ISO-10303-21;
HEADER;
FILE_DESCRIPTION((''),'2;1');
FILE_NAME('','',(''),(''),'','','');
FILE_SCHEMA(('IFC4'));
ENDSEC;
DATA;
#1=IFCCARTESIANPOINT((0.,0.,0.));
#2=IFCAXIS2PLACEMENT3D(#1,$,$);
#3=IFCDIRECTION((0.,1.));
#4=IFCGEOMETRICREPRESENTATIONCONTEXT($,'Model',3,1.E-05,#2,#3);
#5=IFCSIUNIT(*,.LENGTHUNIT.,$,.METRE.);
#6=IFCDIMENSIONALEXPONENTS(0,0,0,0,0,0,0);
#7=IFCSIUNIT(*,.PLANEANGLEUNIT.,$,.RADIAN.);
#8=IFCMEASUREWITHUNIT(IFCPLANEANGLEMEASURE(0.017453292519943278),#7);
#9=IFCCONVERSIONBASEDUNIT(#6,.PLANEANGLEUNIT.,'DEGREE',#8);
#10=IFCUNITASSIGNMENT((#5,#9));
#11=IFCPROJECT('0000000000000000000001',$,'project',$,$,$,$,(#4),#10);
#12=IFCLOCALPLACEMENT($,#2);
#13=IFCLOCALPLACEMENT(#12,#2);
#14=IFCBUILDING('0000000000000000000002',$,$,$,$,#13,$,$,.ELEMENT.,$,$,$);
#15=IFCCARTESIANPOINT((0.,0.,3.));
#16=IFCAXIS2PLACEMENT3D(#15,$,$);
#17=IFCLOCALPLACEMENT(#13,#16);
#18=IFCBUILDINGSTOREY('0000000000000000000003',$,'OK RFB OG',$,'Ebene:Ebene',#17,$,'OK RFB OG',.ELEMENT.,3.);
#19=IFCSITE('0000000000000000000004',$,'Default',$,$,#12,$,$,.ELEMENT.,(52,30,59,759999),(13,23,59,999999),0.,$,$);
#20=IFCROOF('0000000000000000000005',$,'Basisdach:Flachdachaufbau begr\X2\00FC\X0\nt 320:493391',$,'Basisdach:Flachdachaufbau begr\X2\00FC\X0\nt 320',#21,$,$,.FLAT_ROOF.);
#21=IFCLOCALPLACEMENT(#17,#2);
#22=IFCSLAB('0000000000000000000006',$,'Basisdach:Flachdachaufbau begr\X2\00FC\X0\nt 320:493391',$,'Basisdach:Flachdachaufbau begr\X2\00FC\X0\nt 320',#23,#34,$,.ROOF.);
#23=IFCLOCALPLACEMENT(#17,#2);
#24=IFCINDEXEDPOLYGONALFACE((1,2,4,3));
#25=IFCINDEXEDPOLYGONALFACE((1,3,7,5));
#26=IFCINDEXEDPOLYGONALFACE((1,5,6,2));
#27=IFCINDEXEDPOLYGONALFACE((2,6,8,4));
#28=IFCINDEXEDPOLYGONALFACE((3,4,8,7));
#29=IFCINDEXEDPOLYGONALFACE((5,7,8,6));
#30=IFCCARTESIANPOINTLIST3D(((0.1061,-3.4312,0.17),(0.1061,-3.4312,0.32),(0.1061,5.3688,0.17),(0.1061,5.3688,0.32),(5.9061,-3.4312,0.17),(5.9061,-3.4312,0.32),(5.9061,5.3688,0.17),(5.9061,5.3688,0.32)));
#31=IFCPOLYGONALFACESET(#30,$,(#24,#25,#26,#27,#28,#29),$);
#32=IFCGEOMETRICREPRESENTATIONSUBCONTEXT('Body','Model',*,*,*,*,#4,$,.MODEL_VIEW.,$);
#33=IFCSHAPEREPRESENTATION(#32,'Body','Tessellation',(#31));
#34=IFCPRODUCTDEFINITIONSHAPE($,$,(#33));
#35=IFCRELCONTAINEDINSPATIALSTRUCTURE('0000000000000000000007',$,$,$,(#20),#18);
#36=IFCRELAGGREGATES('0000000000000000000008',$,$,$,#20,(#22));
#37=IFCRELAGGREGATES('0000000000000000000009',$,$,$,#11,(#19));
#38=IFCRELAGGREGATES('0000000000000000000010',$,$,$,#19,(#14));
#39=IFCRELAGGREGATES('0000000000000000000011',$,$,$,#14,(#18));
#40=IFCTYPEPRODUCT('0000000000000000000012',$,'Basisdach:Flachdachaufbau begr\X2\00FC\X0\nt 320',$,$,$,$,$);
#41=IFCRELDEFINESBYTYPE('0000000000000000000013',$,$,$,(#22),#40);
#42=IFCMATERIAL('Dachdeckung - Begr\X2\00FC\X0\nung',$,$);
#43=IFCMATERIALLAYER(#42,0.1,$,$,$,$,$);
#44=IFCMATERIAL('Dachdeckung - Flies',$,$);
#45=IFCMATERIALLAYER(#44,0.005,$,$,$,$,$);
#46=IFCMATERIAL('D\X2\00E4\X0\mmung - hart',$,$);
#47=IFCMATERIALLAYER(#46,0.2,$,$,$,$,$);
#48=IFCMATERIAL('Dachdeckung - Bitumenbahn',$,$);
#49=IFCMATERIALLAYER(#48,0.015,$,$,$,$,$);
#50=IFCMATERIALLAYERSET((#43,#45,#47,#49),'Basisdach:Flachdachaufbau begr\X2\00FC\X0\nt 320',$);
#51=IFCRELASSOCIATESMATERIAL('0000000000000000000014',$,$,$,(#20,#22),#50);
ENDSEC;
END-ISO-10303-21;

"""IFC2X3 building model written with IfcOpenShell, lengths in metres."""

from ifc_helpers import new_model, entity, si_unit, converted_unit, direction, frame, frame_2d, origin, place, context, subcontext, project, spatial, rectangle, extrude, material, layer, layer_set, type_object, element, aggregate, save


model = new_model("IFC2X3")

# Units and contexts
model_context = context("Model", 3, precision=1e-05, world=origin(), true_north=direction((0.0, 1.0)))
body_context = subcontext(model_context, "Body", "Model", "MODEL_VIEW")
ifc_project = project(units=[si_unit("LENGTHUNIT", "METRE"), converted_unit("PLANEANGLEUNIT", "DEGREE", entity("IfcPlaneAngleMeasure", 0.017453292519943278), si_unit("PLANEANGLEUNIT", "RADIAN"), dimensions=[0, 0, 0, 0, 0, 0, 0])], contexts=[model_context])

# Site, building, storey
site_placement = place(None, origin())
site = spatial("IfcSite", under=ifc_project, at=site_placement, Name="Default", CompositionType="ELEMENT", RefLatitude=(52, 30, 59, 759999), RefLongitude=(13, 23, 59, 999999), RefElevation=0.0)
building_placement = place(site_placement, origin())
building = spatial("IfcBuilding", under=site, at=building_placement, CompositionType="ELEMENT")
storey_placement = place(building_placement, frame((0.0, 0.0, 3.0)))
storey = spatial("IfcBuildingStorey", under=building, at=storey_placement, Name="OK RFB OG", ObjectType="Ebene:Ebene", LongName="OK RFB OG", CompositionType="ELEMENT", Elevation=3.0)

# Roof, slab
ifc_material_1 = material(Name="Dachdeckung - Begrünung")
ifc_layer_1 = layer(ifc_material_1, 0.1)
ifc_material_2 = material(Name="Dachdeckung - Flies")
ifc_layer_2 = layer(ifc_material_2, 0.005)
ifc_material_3 = material(Name="Dämmung - hart")
ifc_layer_3 = layer(ifc_material_3, 0.2)
ifc_material_4 = material(Name="Dachdeckung - Bitumenbahn")
ifc_layer_4 = layer(ifc_material_4, 0.015)
ifc_layer_set = layer_set([ifc_layer_1, ifc_layer_2, ifc_layer_3, ifc_layer_4], Name="Basisdach:Flachdachaufbau begrünt 320")
roof_placement = place(storey_placement, frame((0.1061, -3.4312, 0.17)))
roof = element("IfcRoof", 1, at=roof_placement, inside=storey, material=ifc_layer_set, Name="Basisdach:Flachdachaufbau begrünt 320:493391", ObjectType="Basisdach:Flachdachaufbau begrünt 320", ShapeType="FLAT_ROOF")
type_product = type_object("IfcTypeProduct", Name="Basisdach:Flachdachaufbau begrünt 320")
slab_placement = place(roof_placement, origin())
slab = element("IfcSlab", 2, at=slab_placement, type_object=type_product, material=ifc_layer_set, Name="Basisdach:Flachdachaufbau begrünt 320:493391", ObjectType="Basisdach:Flachdachaufbau begrünt 320", PredefinedType="ROOF", context=body_context, shape_type="SweptSolid", body=[
    extrude(rectangle(XDim=8.8, YDim=5.8, at=frame_2d((0.0, 0.0), x_axis=(0.0, 1.0))), frame((2.9, 4.4, 0.0)), (0.0, 0.0, 1.0), 0.15),
])
aggregate(roof, [slab])

save(model, "model.ifc")
